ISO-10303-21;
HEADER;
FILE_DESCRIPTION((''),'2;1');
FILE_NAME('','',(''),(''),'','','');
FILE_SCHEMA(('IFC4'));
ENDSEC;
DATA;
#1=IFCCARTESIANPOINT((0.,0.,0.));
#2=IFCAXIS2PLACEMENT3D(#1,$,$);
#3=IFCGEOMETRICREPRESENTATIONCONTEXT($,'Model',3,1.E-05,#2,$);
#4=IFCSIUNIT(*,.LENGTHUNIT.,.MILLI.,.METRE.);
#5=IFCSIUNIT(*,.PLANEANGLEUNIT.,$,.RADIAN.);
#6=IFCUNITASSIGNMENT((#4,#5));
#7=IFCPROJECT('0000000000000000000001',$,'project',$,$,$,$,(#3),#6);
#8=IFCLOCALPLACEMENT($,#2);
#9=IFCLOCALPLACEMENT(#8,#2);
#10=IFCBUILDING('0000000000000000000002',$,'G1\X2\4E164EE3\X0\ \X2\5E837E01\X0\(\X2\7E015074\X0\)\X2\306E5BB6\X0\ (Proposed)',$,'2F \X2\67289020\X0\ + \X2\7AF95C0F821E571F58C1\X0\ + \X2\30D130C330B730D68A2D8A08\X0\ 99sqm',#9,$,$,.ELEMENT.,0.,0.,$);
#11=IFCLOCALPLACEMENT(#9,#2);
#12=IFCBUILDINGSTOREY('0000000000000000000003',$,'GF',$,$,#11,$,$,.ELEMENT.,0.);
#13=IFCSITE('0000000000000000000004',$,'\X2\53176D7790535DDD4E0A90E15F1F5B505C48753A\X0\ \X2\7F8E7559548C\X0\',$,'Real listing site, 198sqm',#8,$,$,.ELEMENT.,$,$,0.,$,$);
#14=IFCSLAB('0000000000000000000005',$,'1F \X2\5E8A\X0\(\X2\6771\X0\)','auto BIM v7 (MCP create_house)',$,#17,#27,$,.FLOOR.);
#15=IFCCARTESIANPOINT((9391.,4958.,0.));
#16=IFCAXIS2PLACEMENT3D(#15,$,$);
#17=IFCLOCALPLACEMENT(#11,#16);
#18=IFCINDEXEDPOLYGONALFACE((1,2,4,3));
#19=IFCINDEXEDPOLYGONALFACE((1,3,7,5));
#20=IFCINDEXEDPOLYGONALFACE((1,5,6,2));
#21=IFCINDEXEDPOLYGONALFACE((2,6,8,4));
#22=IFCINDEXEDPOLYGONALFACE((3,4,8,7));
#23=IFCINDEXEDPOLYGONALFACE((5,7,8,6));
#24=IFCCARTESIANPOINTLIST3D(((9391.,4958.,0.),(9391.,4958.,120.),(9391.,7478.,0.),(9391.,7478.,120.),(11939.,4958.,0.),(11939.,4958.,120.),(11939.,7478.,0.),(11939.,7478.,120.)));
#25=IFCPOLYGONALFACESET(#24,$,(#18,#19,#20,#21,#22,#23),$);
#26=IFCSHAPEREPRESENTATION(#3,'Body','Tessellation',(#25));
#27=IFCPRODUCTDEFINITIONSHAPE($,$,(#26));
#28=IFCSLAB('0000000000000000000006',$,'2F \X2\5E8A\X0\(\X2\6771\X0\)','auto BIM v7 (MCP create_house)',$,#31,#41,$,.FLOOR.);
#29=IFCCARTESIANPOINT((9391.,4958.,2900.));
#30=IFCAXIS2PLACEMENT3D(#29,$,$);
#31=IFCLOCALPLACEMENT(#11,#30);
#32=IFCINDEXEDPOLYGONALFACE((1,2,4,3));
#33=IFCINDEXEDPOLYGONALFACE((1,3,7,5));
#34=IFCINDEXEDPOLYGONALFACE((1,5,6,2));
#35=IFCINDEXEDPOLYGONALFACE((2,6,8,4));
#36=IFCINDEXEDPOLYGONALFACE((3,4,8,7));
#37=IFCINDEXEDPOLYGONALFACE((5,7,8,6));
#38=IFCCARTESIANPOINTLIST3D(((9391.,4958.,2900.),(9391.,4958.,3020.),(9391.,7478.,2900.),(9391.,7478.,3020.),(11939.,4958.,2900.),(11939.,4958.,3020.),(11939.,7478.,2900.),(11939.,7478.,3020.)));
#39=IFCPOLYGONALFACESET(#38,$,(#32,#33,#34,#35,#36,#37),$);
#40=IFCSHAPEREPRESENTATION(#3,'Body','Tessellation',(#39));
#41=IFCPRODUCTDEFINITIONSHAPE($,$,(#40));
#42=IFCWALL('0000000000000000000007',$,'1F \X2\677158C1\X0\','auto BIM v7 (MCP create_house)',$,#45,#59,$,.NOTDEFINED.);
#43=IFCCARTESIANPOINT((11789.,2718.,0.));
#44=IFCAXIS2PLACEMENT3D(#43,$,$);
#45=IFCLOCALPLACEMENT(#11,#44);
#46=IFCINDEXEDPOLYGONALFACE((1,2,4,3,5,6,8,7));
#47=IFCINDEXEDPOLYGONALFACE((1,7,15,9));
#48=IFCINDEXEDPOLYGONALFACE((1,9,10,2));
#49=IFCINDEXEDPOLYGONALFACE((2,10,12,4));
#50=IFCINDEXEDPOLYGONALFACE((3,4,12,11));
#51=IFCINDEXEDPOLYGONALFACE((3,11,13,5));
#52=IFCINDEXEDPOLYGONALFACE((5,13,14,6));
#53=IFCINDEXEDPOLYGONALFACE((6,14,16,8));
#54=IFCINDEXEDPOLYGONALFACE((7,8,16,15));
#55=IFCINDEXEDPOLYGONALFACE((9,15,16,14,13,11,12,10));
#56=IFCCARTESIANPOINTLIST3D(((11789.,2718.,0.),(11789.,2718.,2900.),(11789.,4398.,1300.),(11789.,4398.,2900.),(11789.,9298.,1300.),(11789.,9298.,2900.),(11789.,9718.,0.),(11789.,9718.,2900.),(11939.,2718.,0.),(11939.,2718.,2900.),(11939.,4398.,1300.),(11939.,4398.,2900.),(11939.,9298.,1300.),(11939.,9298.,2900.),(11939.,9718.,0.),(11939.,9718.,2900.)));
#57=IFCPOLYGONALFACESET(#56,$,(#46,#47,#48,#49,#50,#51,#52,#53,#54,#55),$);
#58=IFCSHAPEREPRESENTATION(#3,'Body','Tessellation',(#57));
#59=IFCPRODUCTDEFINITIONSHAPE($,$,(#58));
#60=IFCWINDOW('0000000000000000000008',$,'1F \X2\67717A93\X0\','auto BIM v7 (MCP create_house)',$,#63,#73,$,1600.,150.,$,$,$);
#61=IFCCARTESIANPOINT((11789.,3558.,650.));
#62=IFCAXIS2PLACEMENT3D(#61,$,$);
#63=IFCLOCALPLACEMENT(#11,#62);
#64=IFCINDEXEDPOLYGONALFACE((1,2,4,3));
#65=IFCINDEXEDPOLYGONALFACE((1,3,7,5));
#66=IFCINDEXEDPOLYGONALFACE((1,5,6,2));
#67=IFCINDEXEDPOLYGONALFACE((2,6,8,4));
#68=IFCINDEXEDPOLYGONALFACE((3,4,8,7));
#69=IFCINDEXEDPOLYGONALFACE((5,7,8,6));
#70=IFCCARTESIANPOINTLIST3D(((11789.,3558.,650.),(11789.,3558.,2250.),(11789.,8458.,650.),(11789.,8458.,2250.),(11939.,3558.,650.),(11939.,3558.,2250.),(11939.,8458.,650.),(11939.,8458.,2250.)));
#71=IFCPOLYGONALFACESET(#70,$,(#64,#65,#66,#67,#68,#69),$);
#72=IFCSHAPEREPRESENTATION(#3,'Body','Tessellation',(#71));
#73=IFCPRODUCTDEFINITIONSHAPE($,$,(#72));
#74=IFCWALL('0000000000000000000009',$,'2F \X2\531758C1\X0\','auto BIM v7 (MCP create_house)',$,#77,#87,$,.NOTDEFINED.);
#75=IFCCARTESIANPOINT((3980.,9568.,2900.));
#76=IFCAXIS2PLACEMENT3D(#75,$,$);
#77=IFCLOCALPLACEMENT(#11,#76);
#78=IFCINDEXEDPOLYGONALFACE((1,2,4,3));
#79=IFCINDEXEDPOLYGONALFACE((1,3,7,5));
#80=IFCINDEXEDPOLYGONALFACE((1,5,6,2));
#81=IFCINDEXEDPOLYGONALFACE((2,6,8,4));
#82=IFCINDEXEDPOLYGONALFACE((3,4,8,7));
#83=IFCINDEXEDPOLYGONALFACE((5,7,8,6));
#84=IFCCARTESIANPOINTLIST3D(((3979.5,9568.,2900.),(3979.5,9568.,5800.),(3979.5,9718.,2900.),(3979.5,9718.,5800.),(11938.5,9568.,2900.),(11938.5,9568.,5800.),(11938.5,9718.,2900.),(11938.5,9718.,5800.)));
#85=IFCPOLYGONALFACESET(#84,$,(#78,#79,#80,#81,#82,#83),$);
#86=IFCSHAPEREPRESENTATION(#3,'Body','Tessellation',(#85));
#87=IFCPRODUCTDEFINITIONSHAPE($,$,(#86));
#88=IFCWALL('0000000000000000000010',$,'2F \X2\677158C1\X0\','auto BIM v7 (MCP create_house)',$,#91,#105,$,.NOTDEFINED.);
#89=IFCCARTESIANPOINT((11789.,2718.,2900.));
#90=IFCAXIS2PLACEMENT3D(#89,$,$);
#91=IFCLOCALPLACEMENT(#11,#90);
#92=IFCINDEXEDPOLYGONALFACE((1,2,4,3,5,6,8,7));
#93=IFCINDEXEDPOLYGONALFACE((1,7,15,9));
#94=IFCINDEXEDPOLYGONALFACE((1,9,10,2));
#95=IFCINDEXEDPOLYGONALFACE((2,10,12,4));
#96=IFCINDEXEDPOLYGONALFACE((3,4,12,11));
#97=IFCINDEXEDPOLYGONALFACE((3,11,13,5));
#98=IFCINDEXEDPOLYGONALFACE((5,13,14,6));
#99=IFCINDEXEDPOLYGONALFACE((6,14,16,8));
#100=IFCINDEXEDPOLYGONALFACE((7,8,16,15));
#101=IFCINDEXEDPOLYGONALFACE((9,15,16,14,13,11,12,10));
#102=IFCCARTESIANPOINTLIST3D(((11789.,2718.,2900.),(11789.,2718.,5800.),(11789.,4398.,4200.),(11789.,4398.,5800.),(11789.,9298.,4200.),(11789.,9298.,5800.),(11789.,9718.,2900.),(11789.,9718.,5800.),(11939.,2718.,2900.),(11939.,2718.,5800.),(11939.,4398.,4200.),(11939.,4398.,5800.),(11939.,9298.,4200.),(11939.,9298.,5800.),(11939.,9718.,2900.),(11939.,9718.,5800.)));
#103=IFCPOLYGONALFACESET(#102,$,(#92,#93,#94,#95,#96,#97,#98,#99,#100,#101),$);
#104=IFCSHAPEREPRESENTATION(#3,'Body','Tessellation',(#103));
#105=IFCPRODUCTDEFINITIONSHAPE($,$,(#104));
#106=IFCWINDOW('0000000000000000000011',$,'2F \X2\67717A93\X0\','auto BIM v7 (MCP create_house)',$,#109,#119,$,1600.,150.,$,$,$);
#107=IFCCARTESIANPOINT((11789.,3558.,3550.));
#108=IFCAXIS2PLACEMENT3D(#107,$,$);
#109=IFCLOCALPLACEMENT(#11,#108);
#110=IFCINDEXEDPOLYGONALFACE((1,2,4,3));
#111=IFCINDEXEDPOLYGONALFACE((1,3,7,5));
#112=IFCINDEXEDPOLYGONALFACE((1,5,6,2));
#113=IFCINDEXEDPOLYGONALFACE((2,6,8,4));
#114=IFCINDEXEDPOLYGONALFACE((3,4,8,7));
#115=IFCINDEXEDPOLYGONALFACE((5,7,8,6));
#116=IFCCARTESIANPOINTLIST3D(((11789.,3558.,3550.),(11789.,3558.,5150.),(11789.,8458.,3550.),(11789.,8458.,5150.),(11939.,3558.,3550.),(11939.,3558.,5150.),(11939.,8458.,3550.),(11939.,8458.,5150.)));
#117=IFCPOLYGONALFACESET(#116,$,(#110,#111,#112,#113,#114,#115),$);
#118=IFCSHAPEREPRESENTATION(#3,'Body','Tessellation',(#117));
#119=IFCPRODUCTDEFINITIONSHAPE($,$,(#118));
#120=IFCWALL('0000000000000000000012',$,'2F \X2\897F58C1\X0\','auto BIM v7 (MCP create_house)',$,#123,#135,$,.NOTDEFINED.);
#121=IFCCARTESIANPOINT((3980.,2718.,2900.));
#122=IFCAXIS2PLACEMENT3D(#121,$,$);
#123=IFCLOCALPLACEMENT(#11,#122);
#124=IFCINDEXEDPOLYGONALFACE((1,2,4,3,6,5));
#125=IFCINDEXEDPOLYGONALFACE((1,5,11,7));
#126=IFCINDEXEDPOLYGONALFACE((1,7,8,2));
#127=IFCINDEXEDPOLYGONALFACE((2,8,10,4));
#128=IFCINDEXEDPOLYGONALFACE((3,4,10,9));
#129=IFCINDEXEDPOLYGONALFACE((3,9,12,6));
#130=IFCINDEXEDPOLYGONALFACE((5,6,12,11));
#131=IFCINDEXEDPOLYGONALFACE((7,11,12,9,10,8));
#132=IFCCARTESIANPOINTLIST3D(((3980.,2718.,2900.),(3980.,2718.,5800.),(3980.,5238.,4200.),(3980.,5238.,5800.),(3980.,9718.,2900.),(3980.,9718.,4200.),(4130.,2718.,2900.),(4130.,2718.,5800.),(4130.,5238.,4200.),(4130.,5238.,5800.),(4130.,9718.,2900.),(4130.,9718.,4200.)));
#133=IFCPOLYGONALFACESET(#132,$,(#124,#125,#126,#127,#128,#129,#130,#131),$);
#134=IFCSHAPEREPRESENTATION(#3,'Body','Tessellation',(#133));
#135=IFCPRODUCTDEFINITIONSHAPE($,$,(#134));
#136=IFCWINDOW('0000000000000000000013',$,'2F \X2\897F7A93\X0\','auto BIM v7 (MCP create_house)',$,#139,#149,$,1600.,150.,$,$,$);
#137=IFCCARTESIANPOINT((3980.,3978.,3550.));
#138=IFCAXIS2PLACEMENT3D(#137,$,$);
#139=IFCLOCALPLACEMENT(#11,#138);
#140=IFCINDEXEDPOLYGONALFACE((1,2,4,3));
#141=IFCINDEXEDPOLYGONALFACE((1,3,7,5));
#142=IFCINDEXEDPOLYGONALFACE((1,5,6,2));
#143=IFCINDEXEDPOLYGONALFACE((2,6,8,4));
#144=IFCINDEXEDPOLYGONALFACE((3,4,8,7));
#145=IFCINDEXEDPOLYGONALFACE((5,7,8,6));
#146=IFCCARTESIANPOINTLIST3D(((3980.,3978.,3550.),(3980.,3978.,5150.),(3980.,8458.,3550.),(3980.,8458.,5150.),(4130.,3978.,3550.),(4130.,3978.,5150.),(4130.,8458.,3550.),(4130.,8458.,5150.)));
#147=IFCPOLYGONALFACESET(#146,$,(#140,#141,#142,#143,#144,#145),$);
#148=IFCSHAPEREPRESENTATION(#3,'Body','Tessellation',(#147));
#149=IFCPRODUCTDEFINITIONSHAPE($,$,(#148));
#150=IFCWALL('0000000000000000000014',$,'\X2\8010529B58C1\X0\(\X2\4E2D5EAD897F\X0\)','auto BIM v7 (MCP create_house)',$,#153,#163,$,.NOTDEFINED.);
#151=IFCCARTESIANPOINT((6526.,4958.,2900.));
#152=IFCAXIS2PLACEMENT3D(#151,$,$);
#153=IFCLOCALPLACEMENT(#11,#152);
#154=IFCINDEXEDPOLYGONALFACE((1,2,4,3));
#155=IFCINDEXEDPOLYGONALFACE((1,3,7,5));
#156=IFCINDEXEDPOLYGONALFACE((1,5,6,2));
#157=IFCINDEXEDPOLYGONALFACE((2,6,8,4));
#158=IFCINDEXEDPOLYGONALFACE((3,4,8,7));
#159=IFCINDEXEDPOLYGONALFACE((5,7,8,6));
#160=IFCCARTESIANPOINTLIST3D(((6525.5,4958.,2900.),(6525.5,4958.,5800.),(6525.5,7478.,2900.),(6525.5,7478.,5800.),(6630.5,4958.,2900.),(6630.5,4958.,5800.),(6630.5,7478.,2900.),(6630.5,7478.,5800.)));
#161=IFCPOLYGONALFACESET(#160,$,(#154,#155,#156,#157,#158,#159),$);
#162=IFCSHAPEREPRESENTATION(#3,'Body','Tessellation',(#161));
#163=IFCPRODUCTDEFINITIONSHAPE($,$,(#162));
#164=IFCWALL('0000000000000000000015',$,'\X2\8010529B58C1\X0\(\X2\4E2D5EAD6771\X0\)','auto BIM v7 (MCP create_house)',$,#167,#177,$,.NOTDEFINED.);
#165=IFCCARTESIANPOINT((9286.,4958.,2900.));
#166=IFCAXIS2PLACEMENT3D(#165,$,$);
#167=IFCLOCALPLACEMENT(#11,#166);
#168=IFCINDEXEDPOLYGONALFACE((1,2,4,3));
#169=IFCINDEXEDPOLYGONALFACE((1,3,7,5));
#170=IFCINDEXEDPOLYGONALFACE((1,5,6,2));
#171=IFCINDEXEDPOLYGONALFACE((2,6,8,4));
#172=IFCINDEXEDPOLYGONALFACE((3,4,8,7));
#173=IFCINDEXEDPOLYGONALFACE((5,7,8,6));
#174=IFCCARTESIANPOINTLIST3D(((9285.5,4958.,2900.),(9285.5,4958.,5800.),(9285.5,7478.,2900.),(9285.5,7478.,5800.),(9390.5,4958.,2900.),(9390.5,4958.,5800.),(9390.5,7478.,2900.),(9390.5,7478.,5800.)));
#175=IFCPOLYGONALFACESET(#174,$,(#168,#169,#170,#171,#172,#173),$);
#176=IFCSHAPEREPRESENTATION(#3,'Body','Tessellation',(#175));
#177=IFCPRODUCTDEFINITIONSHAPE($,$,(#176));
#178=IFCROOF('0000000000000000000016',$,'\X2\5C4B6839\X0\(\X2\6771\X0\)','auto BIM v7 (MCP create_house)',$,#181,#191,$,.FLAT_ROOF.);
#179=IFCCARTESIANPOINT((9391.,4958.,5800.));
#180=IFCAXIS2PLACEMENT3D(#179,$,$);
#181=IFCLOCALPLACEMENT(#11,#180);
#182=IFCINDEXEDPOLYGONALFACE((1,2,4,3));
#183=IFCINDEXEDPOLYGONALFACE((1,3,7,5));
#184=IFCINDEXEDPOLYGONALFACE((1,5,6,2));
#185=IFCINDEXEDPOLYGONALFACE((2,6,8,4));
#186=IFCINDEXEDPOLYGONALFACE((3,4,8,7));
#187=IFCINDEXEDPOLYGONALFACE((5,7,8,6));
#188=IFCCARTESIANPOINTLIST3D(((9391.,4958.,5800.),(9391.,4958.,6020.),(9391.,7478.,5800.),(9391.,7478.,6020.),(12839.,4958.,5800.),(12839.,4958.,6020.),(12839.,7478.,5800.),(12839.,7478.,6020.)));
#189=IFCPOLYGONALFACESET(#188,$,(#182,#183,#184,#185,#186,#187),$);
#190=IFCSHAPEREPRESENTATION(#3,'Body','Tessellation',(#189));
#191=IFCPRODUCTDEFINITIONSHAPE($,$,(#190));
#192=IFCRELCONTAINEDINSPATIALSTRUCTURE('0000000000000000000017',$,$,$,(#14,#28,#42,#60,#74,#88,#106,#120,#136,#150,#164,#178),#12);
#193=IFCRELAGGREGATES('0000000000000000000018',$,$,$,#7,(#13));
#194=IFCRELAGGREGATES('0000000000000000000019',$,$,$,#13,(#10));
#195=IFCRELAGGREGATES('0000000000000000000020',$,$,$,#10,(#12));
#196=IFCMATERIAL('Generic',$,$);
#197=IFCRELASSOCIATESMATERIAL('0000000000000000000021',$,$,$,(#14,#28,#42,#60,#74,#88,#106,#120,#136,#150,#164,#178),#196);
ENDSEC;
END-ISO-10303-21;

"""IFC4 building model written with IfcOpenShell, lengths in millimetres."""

from ifc_helpers import new_model, si_unit, frame, frame_2d, origin, place, context, project, spatial, rectangle, extrude, material, element, fill, save


model = new_model("IFC4")

# Units and contexts
model_context = context("Model", 3, precision=1e-05, world=origin())
ifc_project = project(units=[si_unit("LENGTHUNIT", "METRE", prefix="MILLI"), si_unit("PLANEANGLEUNIT", "RADIAN")], contexts=[model_context])

# Site, building, storey
site_placement = place(None, origin())
site = spatial("IfcSite", under=ifc_project, at=site_placement, Name="北海道川上郡弟子屈町 美留和", ObjectType="Real listing site, 198sqm", CompositionType="ELEMENT", RefElevation=0.0)
building_placement = place(site_placement, origin())
building = spatial("IfcBuilding", under=site, at=building_placement, Name="G1世代 広縁(縁側)の家 (Proposed)", ObjectType="2F 木造 + 竹小舞土壁 + パッシブ設計 99sqm", CompositionType="ELEMENT", ElevationOfRefHeight=0.0, ElevationOfTerrain=0.0)
storey_placement = place(building_placement, origin())
storey = spatial("IfcBuildingStorey", under=building, at=storey_placement, Name="GF", CompositionType="ELEMENT", Elevation=0.0)

# Slabs
ifc_material = material(Name="Generic")
slab_1_placement = place(storey_placement, frame((9391.0, 4958.0, 0.0)))
element("IfcSlab", 1, at=slab_1_placement, inside=storey, material=ifc_material, Name="1F 床(東)", Description="auto BIM v7 (MCP create_house)", PredefinedType="FLOOR", context=model_context, shape_type="SweptSolid", body=[
    extrude(rectangle(XDim=2548.0, YDim=2520.0, at=frame_2d((1274.0, 1260.0))), frame((9391.0, 4958.0, 0.0)), (0.0, 0.0, 1.0), 120.0),
])
slab_2_placement = place(storey_placement, frame((9391.0, 4958.0, 2900.0)))
element("IfcSlab", 2, at=slab_2_placement, inside=storey, material=ifc_material, Name="2F 床(東)", Description="auto BIM v7 (MCP create_house)", PredefinedType="FLOOR", context=model_context, shape_type="SweptSolid", body=[
    extrude(rectangle(XDim=2548.0, YDim=2520.0, at=frame_2d((1274.0, 1260.0))), frame((9391.0, 4958.0, 2900.0)), (0.0, 0.0, 1.0), 120.0),
])

# Wall, opening, window
wall_1_placement = place(storey_placement, frame((11789.0, 2718.0, 0.0)))
wall_1 = element("IfcWall", 3, at=wall_1_placement, inside=storey, material=ifc_material, Name="1F 東壁", Description="auto BIM v7 (MCP create_house)", PredefinedType="NOTDEFINED", context=model_context, shape_type="SweptSolid", body=[
    extrude(rectangle(XDim=150.0, YDim=7000.0, at=frame_2d((75.0, 3500.0))), frame((11789.0, 2718.0, 0.0)), (0.0, 0.0, 1.0), 2900.0),
])
opening_1_placement = place(storey_placement, frame((11789.0, 3558.0, 650.0)))
opening_1 = element("IfcOpeningElement", 4, at=opening_1_placement, cuts=wall_1, PredefinedType="NOTDEFINED", context=model_context, shape_type="SweptSolid", body=[
    extrude(rectangle(XDim=150.0, YDim=4900.0, at=frame_2d((75.0, 2450.0))), frame((11789.0, 3558.0, 650.0)), (0.0, 0.0, 1.0), 1600.0),
])
window_1_placement = place(storey_placement, frame((11789.0, 3558.0, 650.0)))
window_1 = element("IfcWindow", 5, at=window_1_placement, inside=storey, material=ifc_material, Name="1F 東窓", Description="auto BIM v7 (MCP create_house)", OverallHeight=1600.0, OverallWidth=150.0, context=model_context, shape_type="SweptSolid", body=[
    extrude(rectangle(XDim=150.0, YDim=4900.0, at=frame_2d((75.0, 2450.0))), frame((11789.0, 3558.0, 650.0)), (0.0, 0.0, 1.0), 1600.0),
])
fill(opening_1, window_1)

# Wall
wall_2_placement = place(storey_placement, frame((3980.0, 9568.0, 2900.0)))
element("IfcWall", 6, at=wall_2_placement, inside=storey, material=ifc_material, Name="2F 北壁", Description="auto BIM v7 (MCP create_house)", PredefinedType="NOTDEFINED", context=model_context, shape_type="SweptSolid", body=[
    extrude(rectangle(XDim=7959.0, YDim=150.0, at=frame_2d((3979.0, 75.0))), frame((3980.0, 9568.0, 2900.0)), (0.0, 0.0, 1.0), 2900.0),
])

# Walls, openings, windows
wall_3_placement = place(storey_placement, frame((11789.0, 2718.0, 2900.0)))
wall_3 = element("IfcWall", 7, at=wall_3_placement, inside=storey, material=ifc_material, Name="2F 東壁", Description="auto BIM v7 (MCP create_house)", PredefinedType="NOTDEFINED", context=model_context, shape_type="SweptSolid", body=[
    extrude(rectangle(XDim=150.0, YDim=7000.0, at=frame_2d((75.0, 3500.0))), frame((11789.0, 2718.0, 2900.0)), (0.0, 0.0, 1.0), 2900.0),
])
opening_2_placement = place(storey_placement, frame((11789.0, 3558.0, 3550.0)))
opening_2 = element("IfcOpeningElement", 8, at=opening_2_placement, cuts=wall_3, PredefinedType="NOTDEFINED", context=model_context, shape_type="SweptSolid", body=[
    extrude(rectangle(XDim=150.0, YDim=4900.0, at=frame_2d((75.0, 2450.0))), frame((11789.0, 3558.0, 3550.0)), (0.0, 0.0, 1.0), 1600.0),
])
window_2_placement = place(storey_placement, frame((11789.0, 3558.0, 3550.0)))
window_2 = element("IfcWindow", 9, at=window_2_placement, inside=storey, material=ifc_material, Name="2F 東窓", Description="auto BIM v7 (MCP create_house)", OverallHeight=1600.0, OverallWidth=150.0, context=model_context, shape_type="SweptSolid", body=[
    extrude(rectangle(XDim=150.0, YDim=4900.0, at=frame_2d((75.0, 2450.0))), frame((11789.0, 3558.0, 3550.0)), (0.0, 0.0, 1.0), 1600.0),
])
fill(opening_2, window_2)
wall_4_placement = place(storey_placement, frame((3980.0, 2718.0, 2900.0)))
wall_4 = element("IfcWall", 10, at=wall_4_placement, inside=storey, material=ifc_material, Name="2F 西壁", Description="auto BIM v7 (MCP create_house)", PredefinedType="NOTDEFINED", context=model_context, shape_type="SweptSolid", body=[
    extrude(rectangle(XDim=150.0, YDim=7000.0, at=frame_2d((75.0, 3500.0))), frame((3980.0, 2718.0, 2900.0)), (0.0, 0.0, 1.0), 2900.0),
])
opening_3_placement = place(storey_placement, frame((3980.0, 3978.0, 3550.0)))
opening_3 = element("IfcOpeningElement", 11, at=opening_3_placement, cuts=wall_4, PredefinedType="NOTDEFINED", context=model_context, shape_type="SweptSolid", body=[
    extrude(rectangle(XDim=150.0, YDim=4480.0, at=frame_2d((75.0, 2240.0))), frame((3980.0, 3978.0, 3550.0)), (0.0, 0.0, 1.0), 1600.0),
])
window_3_placement = place(storey_placement, frame((3980.0, 3978.0, 3550.0)))
window_3 = element("IfcWindow", 12, at=window_3_placement, inside=storey, material=ifc_material, Name="2F 西窓", Description="auto BIM v7 (MCP create_house)", OverallHeight=1600.0, OverallWidth=150.0, context=model_context, shape_type="SweptSolid", body=[
    extrude(rectangle(XDim=150.0, YDim=4480.0, at=frame_2d((75.0, 2240.0))), frame((3980.0, 3978.0, 3550.0)), (0.0, 0.0, 1.0), 1600.0),
])
fill(opening_3, window_3)

# Walls
wall_5_placement = place(storey_placement, frame((6526.0, 4958.0, 2900.0)))
element("IfcWall", 13, at=wall_5_placement, inside=storey, material=ifc_material, Name="耐力壁(中庭西)", Description="auto BIM v7 (MCP create_house)", PredefinedType="NOTDEFINED", context=model_context, shape_type="SweptSolid", body=[
    extrude(rectangle(XDim=105.0, YDim=2520.0, at=frame_2d((52.0, 1260.0))), frame((6526.0, 4958.0, 2900.0)), (0.0, 0.0, 1.0), 2900.0),
])
wall_6_placement = place(storey_placement, frame((9286.0, 4958.0, 2900.0)))
element("IfcWall", 14, at=wall_6_placement, inside=storey, material=ifc_material, Name="耐力壁(中庭東)", Description="auto BIM v7 (MCP create_house)", PredefinedType="NOTDEFINED", context=model_context, shape_type="SweptSolid", body=[
    extrude(rectangle(XDim=105.0, YDim=2520.0, at=frame_2d((52.0, 1260.0))), frame((9286.0, 4958.0, 2900.0)), (0.0, 0.0, 1.0), 2900.0),
])

# Roof
for number, where, name in (
    (15, (9391.0, 4958.0, 5800.0), "屋根(東)"),
):
    element("IfcRoof", number, at=place(storey_placement, frame(where)), inside=storey, material=ifc_material, Name=name, Description="auto BIM v7 (MCP create_house)", PredefinedType="FLAT_ROOF", context=model_context, shape_type="SweptSolid", body=[
        extrude(rectangle(XDim=3448.0, YDim=2520.0, at=frame_2d((1724.0, 1260.0))), frame((9391.0, 4958.0, 5800.0)), (0.0, 0.0, 1.0), 220.0),
    ])

save(model, "model.ifc")
